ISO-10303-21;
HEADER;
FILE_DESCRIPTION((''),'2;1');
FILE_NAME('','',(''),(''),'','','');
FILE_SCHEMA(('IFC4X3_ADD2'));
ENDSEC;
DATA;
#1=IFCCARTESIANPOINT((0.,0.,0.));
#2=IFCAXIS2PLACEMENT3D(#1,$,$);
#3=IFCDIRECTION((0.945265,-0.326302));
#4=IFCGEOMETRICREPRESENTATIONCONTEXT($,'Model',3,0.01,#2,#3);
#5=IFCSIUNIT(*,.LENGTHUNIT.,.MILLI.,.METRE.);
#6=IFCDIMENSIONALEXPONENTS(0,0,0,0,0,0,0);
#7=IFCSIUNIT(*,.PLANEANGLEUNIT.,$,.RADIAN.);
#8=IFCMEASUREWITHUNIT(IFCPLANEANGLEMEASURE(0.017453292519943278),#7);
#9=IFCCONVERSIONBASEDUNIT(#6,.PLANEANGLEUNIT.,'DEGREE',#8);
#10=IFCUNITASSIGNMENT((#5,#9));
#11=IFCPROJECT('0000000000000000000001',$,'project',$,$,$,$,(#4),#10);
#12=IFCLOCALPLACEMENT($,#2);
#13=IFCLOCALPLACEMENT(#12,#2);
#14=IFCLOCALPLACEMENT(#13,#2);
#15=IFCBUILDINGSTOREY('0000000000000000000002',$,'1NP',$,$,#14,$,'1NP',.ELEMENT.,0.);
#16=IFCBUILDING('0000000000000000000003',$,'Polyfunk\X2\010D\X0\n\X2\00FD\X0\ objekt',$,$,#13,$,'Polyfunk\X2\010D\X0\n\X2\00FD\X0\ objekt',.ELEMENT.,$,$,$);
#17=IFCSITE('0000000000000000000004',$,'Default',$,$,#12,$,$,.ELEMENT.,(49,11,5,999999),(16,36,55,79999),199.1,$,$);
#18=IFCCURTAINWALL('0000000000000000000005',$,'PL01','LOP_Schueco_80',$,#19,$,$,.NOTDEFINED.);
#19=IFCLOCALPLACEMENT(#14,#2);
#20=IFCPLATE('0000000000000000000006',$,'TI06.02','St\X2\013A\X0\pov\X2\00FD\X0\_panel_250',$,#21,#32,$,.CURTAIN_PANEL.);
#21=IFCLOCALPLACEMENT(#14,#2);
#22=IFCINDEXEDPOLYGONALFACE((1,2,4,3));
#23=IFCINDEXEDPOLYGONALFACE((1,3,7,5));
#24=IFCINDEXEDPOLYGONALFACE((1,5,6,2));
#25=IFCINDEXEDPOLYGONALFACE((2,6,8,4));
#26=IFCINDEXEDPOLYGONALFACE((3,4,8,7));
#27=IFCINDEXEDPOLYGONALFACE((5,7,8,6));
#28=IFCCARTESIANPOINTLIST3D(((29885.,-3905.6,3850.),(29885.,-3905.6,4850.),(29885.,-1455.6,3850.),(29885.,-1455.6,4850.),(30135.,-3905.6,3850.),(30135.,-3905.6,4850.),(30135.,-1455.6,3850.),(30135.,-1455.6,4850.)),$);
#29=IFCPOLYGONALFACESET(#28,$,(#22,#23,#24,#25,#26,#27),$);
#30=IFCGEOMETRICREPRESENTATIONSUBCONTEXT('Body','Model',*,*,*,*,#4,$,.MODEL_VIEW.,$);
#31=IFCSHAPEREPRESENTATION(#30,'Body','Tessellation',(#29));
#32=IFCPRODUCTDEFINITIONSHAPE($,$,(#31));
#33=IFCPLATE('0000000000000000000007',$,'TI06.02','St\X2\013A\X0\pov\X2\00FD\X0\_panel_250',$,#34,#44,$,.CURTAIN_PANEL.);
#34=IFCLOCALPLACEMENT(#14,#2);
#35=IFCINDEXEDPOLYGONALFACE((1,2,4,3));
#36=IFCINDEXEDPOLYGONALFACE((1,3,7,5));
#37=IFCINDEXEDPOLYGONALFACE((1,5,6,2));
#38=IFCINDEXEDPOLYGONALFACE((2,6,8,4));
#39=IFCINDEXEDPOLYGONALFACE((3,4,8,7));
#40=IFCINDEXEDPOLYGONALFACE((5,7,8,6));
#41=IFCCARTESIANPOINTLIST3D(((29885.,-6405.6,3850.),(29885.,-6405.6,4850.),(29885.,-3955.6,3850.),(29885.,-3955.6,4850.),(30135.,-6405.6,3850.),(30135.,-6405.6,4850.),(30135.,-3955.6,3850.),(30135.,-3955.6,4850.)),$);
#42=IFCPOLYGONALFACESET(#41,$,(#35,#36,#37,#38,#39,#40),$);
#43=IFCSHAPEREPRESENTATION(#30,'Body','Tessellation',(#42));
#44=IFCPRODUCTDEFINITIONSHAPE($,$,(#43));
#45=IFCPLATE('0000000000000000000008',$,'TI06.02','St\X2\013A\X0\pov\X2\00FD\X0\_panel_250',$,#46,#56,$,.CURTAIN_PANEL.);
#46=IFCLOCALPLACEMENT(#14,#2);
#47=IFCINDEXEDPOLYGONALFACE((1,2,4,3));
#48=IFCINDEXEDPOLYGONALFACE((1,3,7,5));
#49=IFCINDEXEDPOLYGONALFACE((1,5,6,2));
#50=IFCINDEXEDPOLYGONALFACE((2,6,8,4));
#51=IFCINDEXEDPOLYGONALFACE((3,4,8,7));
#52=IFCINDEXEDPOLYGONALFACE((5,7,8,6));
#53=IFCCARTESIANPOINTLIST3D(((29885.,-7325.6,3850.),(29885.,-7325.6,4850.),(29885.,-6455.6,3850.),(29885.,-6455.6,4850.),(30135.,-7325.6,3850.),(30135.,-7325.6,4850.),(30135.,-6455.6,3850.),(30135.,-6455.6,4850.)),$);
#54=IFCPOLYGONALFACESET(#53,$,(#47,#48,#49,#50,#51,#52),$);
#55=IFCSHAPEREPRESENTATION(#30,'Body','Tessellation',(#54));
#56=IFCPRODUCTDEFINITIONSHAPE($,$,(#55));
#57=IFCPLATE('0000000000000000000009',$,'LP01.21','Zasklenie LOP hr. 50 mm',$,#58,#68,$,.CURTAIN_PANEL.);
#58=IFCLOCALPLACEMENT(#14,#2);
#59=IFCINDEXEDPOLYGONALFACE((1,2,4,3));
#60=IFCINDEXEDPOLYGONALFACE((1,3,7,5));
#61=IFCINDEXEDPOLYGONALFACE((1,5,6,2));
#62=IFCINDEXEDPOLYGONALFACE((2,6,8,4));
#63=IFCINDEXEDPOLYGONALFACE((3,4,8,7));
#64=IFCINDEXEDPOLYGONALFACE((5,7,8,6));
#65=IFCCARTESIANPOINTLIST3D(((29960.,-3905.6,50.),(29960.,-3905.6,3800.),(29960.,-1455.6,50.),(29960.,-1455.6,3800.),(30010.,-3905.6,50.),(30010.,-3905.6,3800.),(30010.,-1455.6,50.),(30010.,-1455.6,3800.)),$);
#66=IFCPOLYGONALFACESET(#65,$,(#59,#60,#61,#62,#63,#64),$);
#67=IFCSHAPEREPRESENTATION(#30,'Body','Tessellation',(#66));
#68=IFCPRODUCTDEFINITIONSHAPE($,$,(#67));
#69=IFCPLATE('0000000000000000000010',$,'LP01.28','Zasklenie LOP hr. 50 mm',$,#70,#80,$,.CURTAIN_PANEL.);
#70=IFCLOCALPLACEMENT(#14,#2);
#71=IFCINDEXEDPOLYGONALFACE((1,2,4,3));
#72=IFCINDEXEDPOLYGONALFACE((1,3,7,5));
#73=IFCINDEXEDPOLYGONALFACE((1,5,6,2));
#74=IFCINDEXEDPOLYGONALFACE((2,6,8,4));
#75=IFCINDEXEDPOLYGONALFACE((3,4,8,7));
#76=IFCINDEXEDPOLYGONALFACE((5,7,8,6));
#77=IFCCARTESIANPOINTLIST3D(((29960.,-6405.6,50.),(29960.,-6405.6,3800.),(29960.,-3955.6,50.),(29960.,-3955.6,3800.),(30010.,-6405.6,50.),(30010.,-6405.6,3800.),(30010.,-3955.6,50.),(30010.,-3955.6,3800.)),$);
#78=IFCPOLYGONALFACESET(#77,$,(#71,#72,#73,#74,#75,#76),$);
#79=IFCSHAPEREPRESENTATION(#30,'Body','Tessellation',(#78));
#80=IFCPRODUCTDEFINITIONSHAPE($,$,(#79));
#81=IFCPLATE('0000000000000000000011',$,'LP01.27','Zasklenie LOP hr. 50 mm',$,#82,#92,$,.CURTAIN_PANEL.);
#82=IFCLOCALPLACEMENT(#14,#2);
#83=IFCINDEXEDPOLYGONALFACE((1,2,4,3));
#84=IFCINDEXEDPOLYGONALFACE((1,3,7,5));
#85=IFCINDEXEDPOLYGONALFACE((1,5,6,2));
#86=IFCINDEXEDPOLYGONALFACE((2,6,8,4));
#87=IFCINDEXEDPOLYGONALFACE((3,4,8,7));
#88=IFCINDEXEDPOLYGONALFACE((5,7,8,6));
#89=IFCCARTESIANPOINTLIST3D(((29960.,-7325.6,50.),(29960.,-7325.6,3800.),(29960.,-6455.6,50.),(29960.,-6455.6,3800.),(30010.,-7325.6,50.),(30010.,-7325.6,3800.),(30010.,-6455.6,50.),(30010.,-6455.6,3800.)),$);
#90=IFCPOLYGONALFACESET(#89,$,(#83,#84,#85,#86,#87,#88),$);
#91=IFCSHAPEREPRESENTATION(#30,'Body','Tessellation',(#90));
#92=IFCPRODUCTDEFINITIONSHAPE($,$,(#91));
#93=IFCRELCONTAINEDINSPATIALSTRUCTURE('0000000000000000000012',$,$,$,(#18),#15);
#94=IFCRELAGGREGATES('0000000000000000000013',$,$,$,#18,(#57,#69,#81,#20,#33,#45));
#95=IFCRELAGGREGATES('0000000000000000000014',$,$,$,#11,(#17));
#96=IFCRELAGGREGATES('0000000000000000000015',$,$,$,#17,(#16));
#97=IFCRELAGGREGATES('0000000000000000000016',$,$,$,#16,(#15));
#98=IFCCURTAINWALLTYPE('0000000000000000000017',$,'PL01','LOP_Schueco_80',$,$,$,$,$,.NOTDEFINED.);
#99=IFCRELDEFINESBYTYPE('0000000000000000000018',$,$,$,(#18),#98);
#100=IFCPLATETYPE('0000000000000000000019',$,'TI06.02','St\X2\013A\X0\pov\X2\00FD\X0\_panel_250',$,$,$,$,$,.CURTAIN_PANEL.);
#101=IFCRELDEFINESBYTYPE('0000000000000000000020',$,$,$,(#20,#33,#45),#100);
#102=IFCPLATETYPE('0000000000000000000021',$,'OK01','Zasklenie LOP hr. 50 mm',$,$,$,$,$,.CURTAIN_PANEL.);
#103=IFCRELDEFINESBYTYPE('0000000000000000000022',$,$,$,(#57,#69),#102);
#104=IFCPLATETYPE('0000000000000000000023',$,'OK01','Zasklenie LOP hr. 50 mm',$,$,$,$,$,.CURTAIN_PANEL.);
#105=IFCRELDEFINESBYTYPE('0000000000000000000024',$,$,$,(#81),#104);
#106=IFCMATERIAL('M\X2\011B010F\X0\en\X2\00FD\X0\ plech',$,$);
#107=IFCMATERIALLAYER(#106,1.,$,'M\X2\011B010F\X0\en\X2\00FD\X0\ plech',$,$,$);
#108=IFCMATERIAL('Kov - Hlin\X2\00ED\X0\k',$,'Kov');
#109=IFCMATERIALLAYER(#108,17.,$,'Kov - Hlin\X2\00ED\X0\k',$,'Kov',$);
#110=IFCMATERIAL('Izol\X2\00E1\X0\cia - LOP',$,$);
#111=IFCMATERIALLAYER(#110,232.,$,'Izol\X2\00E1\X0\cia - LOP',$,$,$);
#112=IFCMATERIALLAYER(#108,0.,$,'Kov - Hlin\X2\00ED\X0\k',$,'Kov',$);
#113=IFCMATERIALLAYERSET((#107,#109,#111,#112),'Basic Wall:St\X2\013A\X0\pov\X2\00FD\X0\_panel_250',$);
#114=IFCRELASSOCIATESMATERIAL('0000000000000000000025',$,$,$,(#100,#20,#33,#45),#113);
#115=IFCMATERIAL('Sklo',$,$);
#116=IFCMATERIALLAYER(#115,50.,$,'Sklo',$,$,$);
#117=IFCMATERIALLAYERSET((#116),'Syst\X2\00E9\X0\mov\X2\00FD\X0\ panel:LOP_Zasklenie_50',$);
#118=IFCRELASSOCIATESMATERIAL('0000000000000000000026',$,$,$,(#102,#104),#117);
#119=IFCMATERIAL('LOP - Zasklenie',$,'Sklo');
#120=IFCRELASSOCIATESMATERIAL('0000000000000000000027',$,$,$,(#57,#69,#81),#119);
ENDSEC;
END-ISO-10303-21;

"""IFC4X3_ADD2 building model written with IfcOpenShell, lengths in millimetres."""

from ifc_helpers import new_model, entity, si_unit, converted_unit, direction, frame, frame_2d, origin, origin_2d_with_axis, place, context, subcontext, project, spatial, rectangle, extrude, source, transform, mapped, material, layer, layer_set, layer_usage, type_object, type_shapes, element, aggregate, save


model = new_model("IFC4X3_ADD2")

# Units and contexts
model_context = context("Model", 3, precision=0.01, world=origin(), true_north=direction((0.945265, -0.326302)))
body_context = subcontext(model_context, "Body", "Model", "MODEL_VIEW")
ifc_project = project(units=[si_unit("LENGTHUNIT", "METRE", prefix="MILLI"), converted_unit("PLANEANGLEUNIT", "DEGREE", entity("IfcPlaneAngleMeasure", 0.017453292519943278), si_unit("PLANEANGLEUNIT", "RADIAN"), dimensions=[0, 0, 0, 0, 0, 0, 0])], contexts=[model_context])

# Site, building, storey
site_placement = place(None, origin())
site = spatial("IfcSite", under=ifc_project, at=site_placement, Name="Default", CompositionType="ELEMENT", RefLatitude=(49, 11, 5, 999999), RefLongitude=(16, 36, 55, 79999), RefElevation=199.1)
building_placement = place(site_placement, origin())
building = spatial("IfcBuilding", under=site, at=building_placement, Name="Polyfunkčný objekt", LongName="Polyfunkčný objekt", CompositionType="ELEMENT")
storey_placement = place(building_placement, origin())
storey = spatial("IfcBuildingStorey", under=building, at=storey_placement, Name="1NP", LongName="1NP", CompositionType="ELEMENT", Elevation=0.0)

# Curtain wall
curtain_wall_type = type_object("IfcCurtainWallType", Name="PL01", Description="LOP_Schueco_80", PredefinedType="NOTDEFINED")
curtain_wall_1_placement = place(storey_placement, origin())
curtain_wall_1 = element("IfcCurtainWall", 1, at=curtain_wall_1_placement, inside=storey, type_object=curtain_wall_type, Name="PL01", Description="LOP_Schueco_80", PredefinedType="NOTDEFINED")

# Plates
ifc_material_1 = material(Name="Měďený plech")
ifc_layer_1 = layer(ifc_material_1, 1.0, Name="Měďený plech")
ifc_material_2 = material(Name="Kov - Hliník", Category="Kov")
ifc_layer_2 = layer(ifc_material_2, 17.0, Name="Kov - Hliník", Category="Kov")
ifc_material_3 = material(Name="Izolácia - LOP")
ifc_layer_3 = layer(ifc_material_3, 232.0, Name="Izolácia - LOP")
ifc_layer_4 = layer(ifc_material_2, 0.0, Name="Kov - Hliník", Category="Kov")
ifc_layer_set_1 = layer_set([ifc_layer_1, ifc_layer_2, ifc_layer_3, ifc_layer_4], Name="Basic Wall:Stĺpový_panel_250")
plate_type_1 = type_object("IfcPlateType", Name="TI06.02", Description="Stĺpový_panel_250", PredefinedType="CURTAIN_PANEL", material=ifc_layer_set_1)
ifc_layer_usage_1 = layer_usage(ifc_layer_set_1, "AXIS2", "POSITIVE", -125.0)
plate_1_placement = place(storey_placement, frame((30010.0, -1455.6, 3850.0), z_axis=(0.0, 0.0, 1.0), x_axis=(0.0, -1.0, 0.0)))
plate_1 = element("IfcPlate", 2, at=plate_1_placement, type_object=plate_type_1, material=ifc_layer_usage_1, Name="TI06.02", Description="Stĺpový_panel_250", PredefinedType="CURTAIN_PANEL", context=body_context, shape_type="SweptSolid", body=[
    extrude(rectangle(XDim=250.0, YDim=2450.0, at=frame_2d((0.0, 0.0), x_axis=(1.0, 0.0))), frame((1225.0, 0.0, 0.0), z_axis=(0.0, 0.0, 1.0), x_axis=(0.0, 1.0, 0.0)), (0.0, 0.0, 1.0), 1000.0),
])
ifc_layer_usage_2 = layer_usage(ifc_layer_set_1, "AXIS2", "POSITIVE", -125.0)
plate_2_placement = place(storey_placement, frame((30010.0, -3955.6, 3850.0), z_axis=(0.0, 0.0, 1.0), x_axis=(0.0, -1.0, 0.0)))
plate_2 = element("IfcPlate", 3, at=plate_2_placement, type_object=plate_type_1, material=ifc_layer_usage_2, Name="TI06.02", Description="Stĺpový_panel_250", PredefinedType="CURTAIN_PANEL", context=body_context, shape_type="SweptSolid", body=[
    extrude(rectangle(XDim=250.0, YDim=2450.0, at=origin_2d_with_axis()), frame((1225.0, 0.0, 0.0), z_axis=(0.0, 0.0, 1.0), x_axis=(0.0, 1.0, 0.0)), (0.0, 0.0, 1.0), 1000.0),
])
ifc_layer_usage_3 = layer_usage(ifc_layer_set_1, "AXIS2", "POSITIVE", -125.0)
plate_3_placement = place(storey_placement, frame((30010.0, -6455.6, 3850.0), z_axis=(0.0, 0.0, 1.0), x_axis=(0.0, -1.0, 0.0)))
plate_3 = element("IfcPlate", 4, at=plate_3_placement, type_object=plate_type_1, material=ifc_layer_usage_3, Name="TI06.02", Description="Stĺpový_panel_250", PredefinedType="CURTAIN_PANEL", context=body_context, shape_type="SweptSolid", body=[
    extrude(rectangle(XDim=250.0, YDim=870.0, at=frame_2d((0.0, 0.0), x_axis=(1.0, 0.0))), frame((435.0, 0.0, 0.0), z_axis=(0.0, 0.0, 1.0), x_axis=(0.0, 1.0, 0.0)), (0.0, 0.0, 1.0), 1000.0),
])
ifc_material_4 = material(Name="LOP - Zasklenie", Category="Sklo")
ifc_material_5 = material(Name="Sklo")
ifc_layer_5 = layer(ifc_material_5, 50.0, Name="Sklo")
ifc_layer_set_2 = layer_set([ifc_layer_5], Name="Systémový panel:LOP_Zasklenie_50")
plate_type_2 = type_object("IfcPlateType", Name="OK01", Description="Zasklenie LOP hr. 50 mm", PredefinedType="CURTAIN_PANEL", material=ifc_layer_set_2)
shared_shape_1 = source(origin(), body_context, "Body", "SweptSolid", [
    extrude(rectangle(XDim=3750.0, YDim=2450.0, at=frame_2d((-141.7, 0.0), x_axis=(1.0, 0.0))), frame((0.0, -50.0, 2016.7), z_axis=(0.0, 1.0, 0.0), x_axis=(0.0, 0.0, 1.0)), (0.0, 0.0, 1.0), 50.0),
])
type_shapes(plate_type_2, [shared_shape_1])
plate_4_placement = place(curtain_wall_1_placement, frame((30010.0, -2680.6, 50.0), z_axis=(0.0, 0.0, 1.0), x_axis=(0.0, -1.0, 0.0)))
plate_4 = element("IfcPlate", 5, at=plate_4_placement, type_object=plate_type_2, material=ifc_material_4, Name="LP01.21", Description="Zasklenie LOP hr. 50 mm", PredefinedType="CURTAIN_PANEL", context=body_context, shape_type="MappedRepresentation", body=[
    mapped(shared_shape_1, transform((0.0, 0.0, 0.0), scale=1.0)),
])
plate_5_placement = place(curtain_wall_1_placement, frame((30010.0, -5180.6, 50.0), z_axis=(0.0, 0.0, 1.0), x_axis=(0.0, -1.0, 0.0)))
plate_5 = element("IfcPlate", 6, at=plate_5_placement, type_object=plate_type_2, material=ifc_material_4, Name="LP01.28", Description="Zasklenie LOP hr. 50 mm", PredefinedType="CURTAIN_PANEL", context=body_context, shape_type="MappedRepresentation", body=[
    mapped(shared_shape_1, transform((0.0, 0.0, 0.0), scale=1.0)),
])
plate_type_3 = type_object("IfcPlateType", Name="OK01", Description="Zasklenie LOP hr. 50 mm", PredefinedType="CURTAIN_PANEL", material=ifc_layer_set_2)
shared_shape_2 = source(origin(), body_context, "Body", "SweptSolid", [
    extrude(rectangle(XDim=3750.0, YDim=870.0, at=frame_2d((-141.7, 0.0), x_axis=(1.0, 0.0))), frame((0.0, -50.0, 2016.7), z_axis=(0.0, 1.0, 0.0), x_axis=(0.0, 0.0, 1.0)), (0.0, 0.0, 1.0), 50.0),
])
type_shapes(plate_type_3, [shared_shape_2])
plate_6_placement = place(curtain_wall_1_placement, frame((30010.0, -6890.6, 50.0), z_axis=(0.0, 0.0, 1.0), x_axis=(0.0, -1.0, 0.0)))
plate_6 = element("IfcPlate", 7, at=plate_6_placement, type_object=plate_type_3, material=ifc_material_4, Name="LP01.27", Description="Zasklenie LOP hr. 50 mm", PredefinedType="CURTAIN_PANEL", context=body_context, shape_type="MappedRepresentation", body=[
    mapped(shared_shape_2, transform((0.0, 0.0, 0.0), scale=1.0)),
])
aggregate(curtain_wall_1, [plate_4, plate_5, plate_6, plate_1, plate_2, plate_3])

save(model, "model.ifc")
